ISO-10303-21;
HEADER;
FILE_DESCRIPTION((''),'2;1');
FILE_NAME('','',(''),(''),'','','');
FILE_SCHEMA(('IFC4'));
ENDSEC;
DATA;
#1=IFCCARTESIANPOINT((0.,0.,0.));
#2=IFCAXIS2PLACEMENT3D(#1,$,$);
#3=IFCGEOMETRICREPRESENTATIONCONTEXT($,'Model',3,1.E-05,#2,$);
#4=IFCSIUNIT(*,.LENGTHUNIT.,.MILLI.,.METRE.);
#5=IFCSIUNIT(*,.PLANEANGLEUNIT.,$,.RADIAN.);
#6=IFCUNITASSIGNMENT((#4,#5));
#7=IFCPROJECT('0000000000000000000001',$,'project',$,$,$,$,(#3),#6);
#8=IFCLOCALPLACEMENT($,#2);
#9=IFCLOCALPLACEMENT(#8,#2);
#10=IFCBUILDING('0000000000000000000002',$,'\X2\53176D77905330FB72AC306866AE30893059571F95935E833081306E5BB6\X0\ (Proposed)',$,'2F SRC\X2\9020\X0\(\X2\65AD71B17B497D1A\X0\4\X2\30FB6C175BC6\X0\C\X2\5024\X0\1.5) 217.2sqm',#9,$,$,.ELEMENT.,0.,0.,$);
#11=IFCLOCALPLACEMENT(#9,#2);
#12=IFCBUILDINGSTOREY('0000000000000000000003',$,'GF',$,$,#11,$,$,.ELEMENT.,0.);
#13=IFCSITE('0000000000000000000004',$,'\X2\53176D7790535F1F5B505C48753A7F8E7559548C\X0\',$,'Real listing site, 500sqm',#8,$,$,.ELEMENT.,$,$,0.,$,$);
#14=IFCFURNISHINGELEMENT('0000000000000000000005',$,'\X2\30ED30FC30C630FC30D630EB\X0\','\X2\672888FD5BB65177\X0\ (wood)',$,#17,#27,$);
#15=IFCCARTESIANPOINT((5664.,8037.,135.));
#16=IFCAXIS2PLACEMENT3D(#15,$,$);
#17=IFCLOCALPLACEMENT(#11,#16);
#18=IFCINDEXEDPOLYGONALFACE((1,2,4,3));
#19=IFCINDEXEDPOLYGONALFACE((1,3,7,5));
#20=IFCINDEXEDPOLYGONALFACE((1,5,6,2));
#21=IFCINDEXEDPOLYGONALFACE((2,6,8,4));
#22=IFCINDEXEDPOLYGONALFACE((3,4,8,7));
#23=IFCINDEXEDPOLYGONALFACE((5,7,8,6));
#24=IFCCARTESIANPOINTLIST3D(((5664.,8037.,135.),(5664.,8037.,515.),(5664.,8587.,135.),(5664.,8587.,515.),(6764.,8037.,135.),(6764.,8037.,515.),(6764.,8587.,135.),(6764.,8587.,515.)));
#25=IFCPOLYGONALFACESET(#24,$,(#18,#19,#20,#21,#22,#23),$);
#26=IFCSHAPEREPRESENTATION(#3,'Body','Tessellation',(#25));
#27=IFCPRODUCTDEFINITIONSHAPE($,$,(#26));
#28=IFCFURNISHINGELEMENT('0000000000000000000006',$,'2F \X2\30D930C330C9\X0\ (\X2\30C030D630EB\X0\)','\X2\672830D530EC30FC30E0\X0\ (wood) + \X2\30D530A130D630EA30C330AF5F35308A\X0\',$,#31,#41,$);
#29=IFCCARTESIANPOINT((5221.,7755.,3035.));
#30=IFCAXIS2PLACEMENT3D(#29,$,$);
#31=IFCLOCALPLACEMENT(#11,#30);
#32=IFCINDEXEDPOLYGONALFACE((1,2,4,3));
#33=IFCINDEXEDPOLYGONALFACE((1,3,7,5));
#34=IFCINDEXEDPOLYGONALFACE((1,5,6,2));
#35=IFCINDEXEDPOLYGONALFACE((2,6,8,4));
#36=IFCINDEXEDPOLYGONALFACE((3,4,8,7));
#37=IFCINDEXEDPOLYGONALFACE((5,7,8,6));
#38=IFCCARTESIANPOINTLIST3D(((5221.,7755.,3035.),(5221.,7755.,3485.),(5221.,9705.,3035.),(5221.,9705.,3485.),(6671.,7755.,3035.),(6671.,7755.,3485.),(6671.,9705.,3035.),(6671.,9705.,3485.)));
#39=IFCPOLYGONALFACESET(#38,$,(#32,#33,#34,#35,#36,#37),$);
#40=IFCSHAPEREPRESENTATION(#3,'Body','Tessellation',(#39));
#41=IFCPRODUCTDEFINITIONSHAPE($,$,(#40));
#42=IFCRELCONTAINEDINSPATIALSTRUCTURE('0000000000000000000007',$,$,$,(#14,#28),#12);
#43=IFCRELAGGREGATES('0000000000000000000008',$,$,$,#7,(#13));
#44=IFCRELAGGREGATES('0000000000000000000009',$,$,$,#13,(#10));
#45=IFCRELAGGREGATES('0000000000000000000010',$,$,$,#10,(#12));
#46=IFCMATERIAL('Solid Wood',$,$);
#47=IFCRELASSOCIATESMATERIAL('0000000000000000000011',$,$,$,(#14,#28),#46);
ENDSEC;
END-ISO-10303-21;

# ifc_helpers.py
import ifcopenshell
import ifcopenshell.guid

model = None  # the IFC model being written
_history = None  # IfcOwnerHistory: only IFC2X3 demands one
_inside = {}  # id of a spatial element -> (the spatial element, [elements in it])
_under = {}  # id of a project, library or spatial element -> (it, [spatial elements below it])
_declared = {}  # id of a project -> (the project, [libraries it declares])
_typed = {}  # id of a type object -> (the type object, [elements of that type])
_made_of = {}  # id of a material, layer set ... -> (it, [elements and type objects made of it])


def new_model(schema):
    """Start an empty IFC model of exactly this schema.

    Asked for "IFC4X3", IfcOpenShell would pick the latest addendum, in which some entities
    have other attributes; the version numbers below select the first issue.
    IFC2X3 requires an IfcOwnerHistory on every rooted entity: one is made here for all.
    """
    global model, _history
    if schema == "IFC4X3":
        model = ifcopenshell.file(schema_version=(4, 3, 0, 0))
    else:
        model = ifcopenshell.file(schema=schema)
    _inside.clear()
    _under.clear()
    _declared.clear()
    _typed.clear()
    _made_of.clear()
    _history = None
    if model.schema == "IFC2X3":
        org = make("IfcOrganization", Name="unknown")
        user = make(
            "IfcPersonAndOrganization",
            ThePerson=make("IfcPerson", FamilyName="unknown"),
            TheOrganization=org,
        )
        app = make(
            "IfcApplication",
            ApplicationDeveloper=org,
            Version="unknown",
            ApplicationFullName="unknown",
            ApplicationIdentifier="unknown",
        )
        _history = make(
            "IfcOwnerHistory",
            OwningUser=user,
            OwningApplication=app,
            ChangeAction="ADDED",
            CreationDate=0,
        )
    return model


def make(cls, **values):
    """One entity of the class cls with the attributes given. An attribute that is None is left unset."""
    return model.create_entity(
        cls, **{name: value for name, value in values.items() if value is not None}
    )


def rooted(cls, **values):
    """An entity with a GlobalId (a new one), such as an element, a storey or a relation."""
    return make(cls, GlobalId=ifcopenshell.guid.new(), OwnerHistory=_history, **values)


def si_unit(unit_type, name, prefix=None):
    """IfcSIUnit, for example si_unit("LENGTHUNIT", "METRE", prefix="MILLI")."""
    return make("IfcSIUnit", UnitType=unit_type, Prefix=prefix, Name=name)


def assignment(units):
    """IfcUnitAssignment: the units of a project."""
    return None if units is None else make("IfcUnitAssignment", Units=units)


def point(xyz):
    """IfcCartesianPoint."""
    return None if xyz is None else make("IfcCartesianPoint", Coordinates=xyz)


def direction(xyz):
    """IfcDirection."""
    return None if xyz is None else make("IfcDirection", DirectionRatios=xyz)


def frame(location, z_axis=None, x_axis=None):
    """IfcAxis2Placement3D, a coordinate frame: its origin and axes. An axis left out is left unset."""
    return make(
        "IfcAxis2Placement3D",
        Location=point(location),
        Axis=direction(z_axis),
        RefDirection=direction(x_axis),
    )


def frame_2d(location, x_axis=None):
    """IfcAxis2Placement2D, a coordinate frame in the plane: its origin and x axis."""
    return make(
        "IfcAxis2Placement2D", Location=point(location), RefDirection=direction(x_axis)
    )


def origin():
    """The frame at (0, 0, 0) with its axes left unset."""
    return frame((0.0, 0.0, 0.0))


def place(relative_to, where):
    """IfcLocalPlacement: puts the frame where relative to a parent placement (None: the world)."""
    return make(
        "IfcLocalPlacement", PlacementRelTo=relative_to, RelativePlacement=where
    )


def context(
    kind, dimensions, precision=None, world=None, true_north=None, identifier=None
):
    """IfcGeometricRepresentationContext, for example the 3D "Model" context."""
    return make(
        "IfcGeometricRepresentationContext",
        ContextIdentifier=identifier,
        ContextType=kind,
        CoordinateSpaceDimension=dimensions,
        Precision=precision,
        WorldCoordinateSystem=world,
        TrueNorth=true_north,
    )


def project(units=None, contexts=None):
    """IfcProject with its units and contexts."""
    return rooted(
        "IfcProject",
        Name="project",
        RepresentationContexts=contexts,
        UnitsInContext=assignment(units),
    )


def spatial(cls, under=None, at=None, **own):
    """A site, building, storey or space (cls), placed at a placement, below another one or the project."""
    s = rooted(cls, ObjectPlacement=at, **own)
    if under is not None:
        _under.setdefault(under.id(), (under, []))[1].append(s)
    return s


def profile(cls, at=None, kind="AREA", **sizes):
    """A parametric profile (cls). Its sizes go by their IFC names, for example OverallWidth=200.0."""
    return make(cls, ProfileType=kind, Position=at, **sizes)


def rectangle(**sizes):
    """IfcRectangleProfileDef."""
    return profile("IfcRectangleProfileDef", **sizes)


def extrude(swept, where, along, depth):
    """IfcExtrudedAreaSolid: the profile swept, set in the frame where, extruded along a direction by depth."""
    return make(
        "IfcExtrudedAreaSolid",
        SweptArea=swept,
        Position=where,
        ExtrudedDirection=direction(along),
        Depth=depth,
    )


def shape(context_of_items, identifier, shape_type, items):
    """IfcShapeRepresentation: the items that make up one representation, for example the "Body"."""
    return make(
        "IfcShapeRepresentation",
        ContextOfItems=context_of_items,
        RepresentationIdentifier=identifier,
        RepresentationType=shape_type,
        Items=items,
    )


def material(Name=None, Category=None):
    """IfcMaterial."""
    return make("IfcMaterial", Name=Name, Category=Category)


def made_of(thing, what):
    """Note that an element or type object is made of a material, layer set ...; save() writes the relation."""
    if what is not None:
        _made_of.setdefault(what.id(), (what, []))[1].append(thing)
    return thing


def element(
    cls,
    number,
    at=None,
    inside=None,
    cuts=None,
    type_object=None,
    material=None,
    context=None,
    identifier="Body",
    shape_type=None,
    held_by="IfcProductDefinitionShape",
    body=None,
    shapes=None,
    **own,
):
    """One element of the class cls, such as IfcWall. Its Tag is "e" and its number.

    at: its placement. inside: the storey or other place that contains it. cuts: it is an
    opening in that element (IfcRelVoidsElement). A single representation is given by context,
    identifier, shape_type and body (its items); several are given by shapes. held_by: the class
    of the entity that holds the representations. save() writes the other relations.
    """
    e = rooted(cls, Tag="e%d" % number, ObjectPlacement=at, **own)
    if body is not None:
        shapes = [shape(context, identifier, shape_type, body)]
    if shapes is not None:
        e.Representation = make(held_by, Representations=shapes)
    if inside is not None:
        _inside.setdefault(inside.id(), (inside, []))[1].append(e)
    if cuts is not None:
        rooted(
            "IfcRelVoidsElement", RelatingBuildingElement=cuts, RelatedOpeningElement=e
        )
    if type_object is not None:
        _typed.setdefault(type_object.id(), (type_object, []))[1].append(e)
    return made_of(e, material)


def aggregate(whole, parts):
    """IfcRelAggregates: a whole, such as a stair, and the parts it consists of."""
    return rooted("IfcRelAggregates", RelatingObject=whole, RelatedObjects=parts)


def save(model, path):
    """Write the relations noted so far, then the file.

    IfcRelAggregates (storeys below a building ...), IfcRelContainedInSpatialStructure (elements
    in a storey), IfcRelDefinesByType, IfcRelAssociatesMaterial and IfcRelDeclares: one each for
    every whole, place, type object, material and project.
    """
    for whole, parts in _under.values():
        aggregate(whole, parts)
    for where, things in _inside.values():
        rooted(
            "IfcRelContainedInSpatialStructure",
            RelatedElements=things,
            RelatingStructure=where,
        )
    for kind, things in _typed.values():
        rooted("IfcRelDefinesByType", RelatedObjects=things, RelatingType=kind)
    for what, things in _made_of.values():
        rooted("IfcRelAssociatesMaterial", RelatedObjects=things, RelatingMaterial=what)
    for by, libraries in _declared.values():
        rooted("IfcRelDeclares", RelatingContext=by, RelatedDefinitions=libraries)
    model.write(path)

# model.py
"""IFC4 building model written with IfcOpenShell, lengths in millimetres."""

from ifc_helpers import new_model, si_unit, frame, frame_2d, origin, place, context, project, spatial, rectangle, extrude, material, element, save


model = new_model("IFC4")

# Units and contexts
model_context = context("Model", 3, precision=1e-05, world=origin())
ifc_project = project(units=[si_unit("LENGTHUNIT", "METRE", prefix="MILLI"), si_unit("PLANEANGLEUNIT", "RADIAN")], contexts=[model_context])

# Site, building, storey
site_placement = place(None, origin())
site = spatial("IfcSite", under=ifc_project, at=site_placement, Name="北海道弟子屈町美留和", ObjectType="Real listing site, 500sqm", CompositionType="ELEMENT", RefElevation=0.0)
building_placement = place(site_placement, origin())
building = spatial("IfcBuilding", under=site, at=building_placement, Name="北海道・犬と暮らす土間広めの家 (Proposed)", ObjectType="2F SRC造(断熱等級4・気密C値1.5) 217.2sqm", CompositionType="ELEMENT", ElevationOfRefHeight=0.0, ElevationOfTerrain=0.0)
storey_placement = place(building_placement, origin())
storey = spatial("IfcBuildingStorey", under=building, at=storey_placement, Name="GF", CompositionType="ELEMENT", Elevation=0.0)

# Shared definitions
ifc_material_1 = material(Name="Solid Wood")

# Furnishing elements
furnishing_1_placement = place(storey_placement, frame((5664.0, 8037.0, 135.0)))
element("IfcFurnishingElement", 1, at=furnishing_1_placement, inside=storey, material=ifc_material_1, Name="ローテーブル", Description="木製家具 (wood)", context=model_context, shape_type="SweptSolid", body=[
    extrude(rectangle(XDim=1100.0, YDim=550.0, at=frame_2d((550.0, 275.0))), frame((5664.0, 8037.0, 135.0)), (0.0, 0.0, 1.0), 380.0),
])
furnishing_2_placement = place(storey_placement, frame((5221.0, 7755.0, 3035.0)))
element("IfcFurnishingElement", 2, at=furnishing_2_placement, inside=storey, material=ifc_material_1, Name="2F ベッド (ダブル)", Description="木フレーム (wood) + ファブリック張り", context=model_context, shape_type="SweptSolid", body=[
    extrude(rectangle(XDim=1450.0, YDim=1950.0, at=frame_2d((725.0, 975.0))), frame((5221.0, 7755.0, 3035.0)), (0.0, 0.0, 1.0), 450.0),
])

save(model, "model.ifc")
